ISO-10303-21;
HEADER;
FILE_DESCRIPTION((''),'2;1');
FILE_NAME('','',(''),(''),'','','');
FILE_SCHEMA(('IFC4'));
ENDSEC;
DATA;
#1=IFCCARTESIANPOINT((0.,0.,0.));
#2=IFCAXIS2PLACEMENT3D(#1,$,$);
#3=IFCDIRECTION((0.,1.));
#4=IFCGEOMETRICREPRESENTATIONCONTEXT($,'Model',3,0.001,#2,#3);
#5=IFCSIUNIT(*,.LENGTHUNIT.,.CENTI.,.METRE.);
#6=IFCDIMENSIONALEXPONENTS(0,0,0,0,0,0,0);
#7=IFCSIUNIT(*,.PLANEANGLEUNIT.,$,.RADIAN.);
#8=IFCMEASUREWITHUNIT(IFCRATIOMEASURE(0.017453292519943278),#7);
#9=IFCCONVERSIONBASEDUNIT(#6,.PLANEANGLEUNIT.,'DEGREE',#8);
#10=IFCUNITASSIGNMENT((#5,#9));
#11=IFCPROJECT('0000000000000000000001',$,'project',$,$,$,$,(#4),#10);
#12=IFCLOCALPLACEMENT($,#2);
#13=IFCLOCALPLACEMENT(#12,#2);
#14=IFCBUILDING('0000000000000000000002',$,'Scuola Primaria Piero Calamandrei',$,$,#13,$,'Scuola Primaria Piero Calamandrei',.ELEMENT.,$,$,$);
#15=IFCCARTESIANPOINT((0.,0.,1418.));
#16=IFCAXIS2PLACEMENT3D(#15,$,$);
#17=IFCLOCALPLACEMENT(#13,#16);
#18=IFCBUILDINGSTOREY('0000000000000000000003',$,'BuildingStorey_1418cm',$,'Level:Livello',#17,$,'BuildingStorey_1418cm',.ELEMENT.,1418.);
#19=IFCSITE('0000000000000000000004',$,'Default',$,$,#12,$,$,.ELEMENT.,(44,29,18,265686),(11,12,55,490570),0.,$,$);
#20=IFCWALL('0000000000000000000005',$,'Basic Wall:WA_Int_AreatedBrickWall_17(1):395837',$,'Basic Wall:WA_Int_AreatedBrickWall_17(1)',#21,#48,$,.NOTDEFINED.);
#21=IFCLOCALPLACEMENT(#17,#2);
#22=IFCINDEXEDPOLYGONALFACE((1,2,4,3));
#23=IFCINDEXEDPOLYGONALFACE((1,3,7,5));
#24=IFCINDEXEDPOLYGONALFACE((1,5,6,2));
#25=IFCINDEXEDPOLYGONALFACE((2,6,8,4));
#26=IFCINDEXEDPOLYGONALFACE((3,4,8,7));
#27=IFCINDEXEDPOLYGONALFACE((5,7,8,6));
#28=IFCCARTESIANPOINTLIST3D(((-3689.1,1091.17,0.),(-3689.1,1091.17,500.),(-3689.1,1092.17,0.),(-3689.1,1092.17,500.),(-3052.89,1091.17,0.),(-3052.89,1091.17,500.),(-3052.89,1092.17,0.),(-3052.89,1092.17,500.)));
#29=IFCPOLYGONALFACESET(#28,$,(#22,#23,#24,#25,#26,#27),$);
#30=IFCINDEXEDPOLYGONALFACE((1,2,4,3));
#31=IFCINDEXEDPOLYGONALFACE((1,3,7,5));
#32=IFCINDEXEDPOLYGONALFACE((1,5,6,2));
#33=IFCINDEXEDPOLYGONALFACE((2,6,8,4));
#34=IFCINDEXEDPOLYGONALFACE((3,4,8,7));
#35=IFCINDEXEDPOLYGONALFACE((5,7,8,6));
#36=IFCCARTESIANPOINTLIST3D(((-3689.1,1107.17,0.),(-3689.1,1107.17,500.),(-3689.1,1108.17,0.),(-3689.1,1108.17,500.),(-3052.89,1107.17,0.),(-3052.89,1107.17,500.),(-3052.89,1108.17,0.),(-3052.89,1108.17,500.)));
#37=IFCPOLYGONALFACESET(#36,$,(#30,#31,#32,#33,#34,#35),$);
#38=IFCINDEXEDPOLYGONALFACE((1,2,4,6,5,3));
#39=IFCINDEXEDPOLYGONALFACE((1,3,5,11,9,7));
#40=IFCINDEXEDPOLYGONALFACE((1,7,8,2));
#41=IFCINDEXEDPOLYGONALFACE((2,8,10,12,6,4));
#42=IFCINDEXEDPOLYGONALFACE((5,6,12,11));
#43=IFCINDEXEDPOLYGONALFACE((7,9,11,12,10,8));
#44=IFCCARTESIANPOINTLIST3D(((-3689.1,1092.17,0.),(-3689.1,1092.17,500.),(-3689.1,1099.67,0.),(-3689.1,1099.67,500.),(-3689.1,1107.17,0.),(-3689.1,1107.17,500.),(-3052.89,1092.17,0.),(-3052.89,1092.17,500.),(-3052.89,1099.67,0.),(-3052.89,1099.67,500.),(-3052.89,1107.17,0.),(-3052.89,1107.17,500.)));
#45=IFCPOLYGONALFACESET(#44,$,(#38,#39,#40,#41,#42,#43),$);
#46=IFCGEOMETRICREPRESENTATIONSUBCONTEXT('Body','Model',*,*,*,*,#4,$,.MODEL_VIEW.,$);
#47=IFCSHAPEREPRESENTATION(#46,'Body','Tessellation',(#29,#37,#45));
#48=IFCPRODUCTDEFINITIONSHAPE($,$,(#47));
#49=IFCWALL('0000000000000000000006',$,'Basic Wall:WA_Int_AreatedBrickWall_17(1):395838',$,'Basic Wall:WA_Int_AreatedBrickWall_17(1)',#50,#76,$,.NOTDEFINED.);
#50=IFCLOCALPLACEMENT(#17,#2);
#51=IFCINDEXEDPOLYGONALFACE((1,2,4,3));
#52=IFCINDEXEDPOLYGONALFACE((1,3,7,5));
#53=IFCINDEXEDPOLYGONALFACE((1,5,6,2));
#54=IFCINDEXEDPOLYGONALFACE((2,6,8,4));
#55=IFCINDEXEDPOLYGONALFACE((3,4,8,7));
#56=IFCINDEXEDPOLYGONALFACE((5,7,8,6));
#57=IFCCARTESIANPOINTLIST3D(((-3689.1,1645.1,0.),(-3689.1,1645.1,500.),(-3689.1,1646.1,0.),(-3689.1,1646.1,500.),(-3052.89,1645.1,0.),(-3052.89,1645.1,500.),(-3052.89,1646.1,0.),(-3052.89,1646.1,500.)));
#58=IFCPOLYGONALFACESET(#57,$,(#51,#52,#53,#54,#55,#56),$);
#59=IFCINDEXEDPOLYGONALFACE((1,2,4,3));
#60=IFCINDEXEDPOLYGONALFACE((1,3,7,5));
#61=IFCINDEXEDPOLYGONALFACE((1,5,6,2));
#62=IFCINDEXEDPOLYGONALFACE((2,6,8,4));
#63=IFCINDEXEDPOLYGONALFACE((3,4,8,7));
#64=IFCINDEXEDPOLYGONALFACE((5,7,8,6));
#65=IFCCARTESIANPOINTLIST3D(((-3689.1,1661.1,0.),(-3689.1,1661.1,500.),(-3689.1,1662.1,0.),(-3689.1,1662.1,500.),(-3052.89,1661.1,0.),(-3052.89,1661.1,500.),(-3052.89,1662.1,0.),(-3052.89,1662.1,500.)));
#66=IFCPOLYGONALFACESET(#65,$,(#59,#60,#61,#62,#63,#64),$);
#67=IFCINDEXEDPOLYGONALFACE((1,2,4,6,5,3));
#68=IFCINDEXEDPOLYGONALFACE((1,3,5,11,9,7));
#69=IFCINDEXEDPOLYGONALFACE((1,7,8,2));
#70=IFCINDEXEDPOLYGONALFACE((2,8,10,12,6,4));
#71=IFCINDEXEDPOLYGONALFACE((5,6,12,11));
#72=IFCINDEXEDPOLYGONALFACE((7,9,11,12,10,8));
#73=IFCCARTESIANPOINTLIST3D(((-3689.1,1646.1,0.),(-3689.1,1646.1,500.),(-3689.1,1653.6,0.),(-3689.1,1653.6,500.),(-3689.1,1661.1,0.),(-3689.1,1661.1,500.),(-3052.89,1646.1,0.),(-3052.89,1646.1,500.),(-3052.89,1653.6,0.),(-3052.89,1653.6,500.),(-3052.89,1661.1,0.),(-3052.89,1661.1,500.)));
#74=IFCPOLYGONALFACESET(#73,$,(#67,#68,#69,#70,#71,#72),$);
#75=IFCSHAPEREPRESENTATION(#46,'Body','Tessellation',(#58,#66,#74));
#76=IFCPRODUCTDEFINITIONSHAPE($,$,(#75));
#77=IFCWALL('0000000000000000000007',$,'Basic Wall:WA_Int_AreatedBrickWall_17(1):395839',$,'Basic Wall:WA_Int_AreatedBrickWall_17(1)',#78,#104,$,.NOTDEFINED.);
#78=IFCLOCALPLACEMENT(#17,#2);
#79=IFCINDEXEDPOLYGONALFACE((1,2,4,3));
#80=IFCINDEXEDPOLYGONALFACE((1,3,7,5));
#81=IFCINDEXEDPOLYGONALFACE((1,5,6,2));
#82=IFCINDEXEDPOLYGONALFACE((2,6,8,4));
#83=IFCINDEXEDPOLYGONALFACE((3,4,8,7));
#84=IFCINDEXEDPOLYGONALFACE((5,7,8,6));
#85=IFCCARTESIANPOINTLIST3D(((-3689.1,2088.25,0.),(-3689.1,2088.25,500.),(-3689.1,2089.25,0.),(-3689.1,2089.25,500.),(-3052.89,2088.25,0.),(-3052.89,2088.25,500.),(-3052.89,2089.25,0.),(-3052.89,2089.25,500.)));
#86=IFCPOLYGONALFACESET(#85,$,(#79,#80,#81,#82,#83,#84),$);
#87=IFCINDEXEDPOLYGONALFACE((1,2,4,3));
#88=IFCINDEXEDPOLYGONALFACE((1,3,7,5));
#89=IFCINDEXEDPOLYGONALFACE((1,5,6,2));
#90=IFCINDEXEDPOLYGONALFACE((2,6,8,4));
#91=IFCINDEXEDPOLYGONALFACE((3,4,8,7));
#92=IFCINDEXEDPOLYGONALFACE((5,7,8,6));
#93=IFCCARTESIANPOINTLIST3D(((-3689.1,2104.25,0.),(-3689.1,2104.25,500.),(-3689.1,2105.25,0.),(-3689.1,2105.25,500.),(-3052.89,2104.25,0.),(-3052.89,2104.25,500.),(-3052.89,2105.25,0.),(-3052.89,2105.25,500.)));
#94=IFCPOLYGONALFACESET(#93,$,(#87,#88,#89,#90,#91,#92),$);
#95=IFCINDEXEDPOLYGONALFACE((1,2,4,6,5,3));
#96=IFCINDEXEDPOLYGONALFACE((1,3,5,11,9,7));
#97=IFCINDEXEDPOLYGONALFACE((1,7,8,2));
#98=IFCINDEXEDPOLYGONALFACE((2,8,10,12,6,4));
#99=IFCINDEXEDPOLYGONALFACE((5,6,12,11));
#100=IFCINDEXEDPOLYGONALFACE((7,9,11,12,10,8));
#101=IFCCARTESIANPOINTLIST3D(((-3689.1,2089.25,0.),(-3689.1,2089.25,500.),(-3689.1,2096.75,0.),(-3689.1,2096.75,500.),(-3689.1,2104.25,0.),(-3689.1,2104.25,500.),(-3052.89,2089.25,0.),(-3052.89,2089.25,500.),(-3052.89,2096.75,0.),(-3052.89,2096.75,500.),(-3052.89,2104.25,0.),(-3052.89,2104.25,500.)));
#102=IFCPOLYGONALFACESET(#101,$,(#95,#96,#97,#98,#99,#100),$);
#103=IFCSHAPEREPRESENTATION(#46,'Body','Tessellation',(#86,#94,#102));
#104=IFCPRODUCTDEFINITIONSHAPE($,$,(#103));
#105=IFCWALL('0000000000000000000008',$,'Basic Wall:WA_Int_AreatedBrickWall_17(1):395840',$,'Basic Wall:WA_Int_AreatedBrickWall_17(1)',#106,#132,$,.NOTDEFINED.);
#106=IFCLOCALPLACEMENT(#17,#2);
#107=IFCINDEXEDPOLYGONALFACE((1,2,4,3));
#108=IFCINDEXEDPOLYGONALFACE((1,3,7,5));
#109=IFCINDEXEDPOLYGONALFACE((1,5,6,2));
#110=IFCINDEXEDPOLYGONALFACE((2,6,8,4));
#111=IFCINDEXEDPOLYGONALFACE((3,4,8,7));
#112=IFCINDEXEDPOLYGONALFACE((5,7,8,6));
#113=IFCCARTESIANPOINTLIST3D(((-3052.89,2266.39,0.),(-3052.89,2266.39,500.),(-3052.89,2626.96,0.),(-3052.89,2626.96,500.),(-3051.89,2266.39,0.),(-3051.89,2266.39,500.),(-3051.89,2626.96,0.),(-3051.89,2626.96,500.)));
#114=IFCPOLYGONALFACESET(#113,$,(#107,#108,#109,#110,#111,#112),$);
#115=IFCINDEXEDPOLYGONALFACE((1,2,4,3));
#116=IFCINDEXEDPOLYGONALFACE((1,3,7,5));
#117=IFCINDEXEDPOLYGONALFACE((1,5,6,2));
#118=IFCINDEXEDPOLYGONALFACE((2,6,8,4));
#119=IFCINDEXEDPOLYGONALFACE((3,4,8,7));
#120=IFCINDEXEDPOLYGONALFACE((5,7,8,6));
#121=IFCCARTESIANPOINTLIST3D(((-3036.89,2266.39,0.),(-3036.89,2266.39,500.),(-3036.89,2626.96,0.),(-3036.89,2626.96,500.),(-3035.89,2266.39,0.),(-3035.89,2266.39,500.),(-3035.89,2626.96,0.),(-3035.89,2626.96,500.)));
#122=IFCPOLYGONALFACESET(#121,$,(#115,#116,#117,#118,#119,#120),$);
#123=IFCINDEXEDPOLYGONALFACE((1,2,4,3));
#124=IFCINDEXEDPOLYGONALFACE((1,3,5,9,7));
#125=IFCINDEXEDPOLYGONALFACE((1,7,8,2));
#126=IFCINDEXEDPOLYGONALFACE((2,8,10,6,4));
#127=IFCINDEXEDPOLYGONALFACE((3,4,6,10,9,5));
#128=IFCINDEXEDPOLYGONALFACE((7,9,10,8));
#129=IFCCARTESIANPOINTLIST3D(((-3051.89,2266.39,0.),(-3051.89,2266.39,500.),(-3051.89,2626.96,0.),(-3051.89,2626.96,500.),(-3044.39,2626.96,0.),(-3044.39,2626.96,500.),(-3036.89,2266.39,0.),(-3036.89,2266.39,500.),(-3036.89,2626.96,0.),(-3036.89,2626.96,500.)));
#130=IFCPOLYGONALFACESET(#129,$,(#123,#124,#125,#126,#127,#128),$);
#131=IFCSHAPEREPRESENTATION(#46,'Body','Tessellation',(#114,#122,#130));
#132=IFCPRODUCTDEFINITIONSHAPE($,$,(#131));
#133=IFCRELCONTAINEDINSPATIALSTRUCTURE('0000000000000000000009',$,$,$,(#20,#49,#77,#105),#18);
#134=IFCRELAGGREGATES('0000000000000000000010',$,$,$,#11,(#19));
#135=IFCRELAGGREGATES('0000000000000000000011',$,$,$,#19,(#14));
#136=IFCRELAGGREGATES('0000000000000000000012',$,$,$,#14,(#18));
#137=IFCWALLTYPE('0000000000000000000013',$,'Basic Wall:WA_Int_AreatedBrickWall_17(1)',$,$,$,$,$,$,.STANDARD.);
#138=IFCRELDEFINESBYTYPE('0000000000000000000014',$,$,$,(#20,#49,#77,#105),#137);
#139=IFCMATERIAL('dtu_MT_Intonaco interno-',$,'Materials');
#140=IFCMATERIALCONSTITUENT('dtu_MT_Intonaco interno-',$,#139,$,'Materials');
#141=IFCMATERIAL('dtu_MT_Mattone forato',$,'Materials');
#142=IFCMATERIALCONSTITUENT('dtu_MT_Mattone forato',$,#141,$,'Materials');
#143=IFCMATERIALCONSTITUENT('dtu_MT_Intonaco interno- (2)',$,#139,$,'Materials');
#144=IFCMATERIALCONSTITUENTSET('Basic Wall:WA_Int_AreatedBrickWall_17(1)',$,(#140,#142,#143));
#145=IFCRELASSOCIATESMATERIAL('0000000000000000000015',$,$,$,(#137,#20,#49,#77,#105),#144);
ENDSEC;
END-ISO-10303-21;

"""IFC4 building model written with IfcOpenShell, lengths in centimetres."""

from ifc_helpers import new_model, entity, si_unit, converted_unit, direction, frame, origin, place, context, subcontext, project, spatial, indexed_curve, outline, extrude, material, constituent, constituent_set, type_object, element, save


model = new_model("IFC4")

# Units and contexts
model_context = context("Model", 3, precision=0.001, world=origin(), true_north=direction((0.0, 1.0)))
body_context = subcontext(model_context, "Body", "Model", "MODEL_VIEW")
ifc_project = project(units=[si_unit("LENGTHUNIT", "METRE", prefix="CENTI"), converted_unit("PLANEANGLEUNIT", "DEGREE", entity("IfcRatioMeasure", 0.017453292519943278), si_unit("PLANEANGLEUNIT", "RADIAN"), dimensions=[0, 0, 0, 0, 0, 0, 0])], contexts=[model_context])

# Site, building, storey
site_placement = place(None, origin())
site = spatial("IfcSite", under=ifc_project, at=site_placement, Name="Default", CompositionType="ELEMENT", RefLatitude=(44, 29, 18, 265686), RefLongitude=(11, 12, 55, 490570), RefElevation=0.0)
building_placement = place(site_placement, origin())
building = spatial("IfcBuilding", under=site, at=building_placement, Name="Scuola Primaria Piero Calamandrei", LongName="Scuola Primaria Piero Calamandrei", CompositionType="ELEMENT")
storey_placement = place(building_placement, frame((0.0, 0.0, 1418.0)))
storey = spatial("IfcBuildingStorey", under=building, at=storey_placement, Name="BuildingStorey_1418cm", ObjectType="Level:Livello", LongName="BuildingStorey_1418cm", CompositionType="ELEMENT", Elevation=1418.0)

# Shared definitions
ifc_material_1 = material(Name="dtu_MT_Intonaco interno-", Category="Materials")
ifc_constituent_1 = constituent(ifc_material_1, Name="dtu_MT_Intonaco interno-", Category="Materials")
ifc_material_2 = material(Name="dtu_MT_Mattone forato", Category="Materials")
ifc_constituent_2 = constituent(ifc_material_2, Name="dtu_MT_Mattone forato", Category="Materials")
ifc_constituent_3 = constituent(ifc_material_1, Name="dtu_MT_Intonaco interno- (2)", Category="Materials")
ifc_constituent_set_1 = constituent_set(constituents=[ifc_constituent_1, ifc_constituent_2, ifc_constituent_3], Name="Basic Wall:WA_Int_AreatedBrickWall_17(1)")
wall_type_1 = type_object("IfcWallType", Name="Basic Wall:WA_Int_AreatedBrickWall_17(1)", PredefinedType="STANDARD", material=ifc_constituent_set_1)

# Walls
wall_1_placement = place(storey_placement, frame((-3689.1, 1099.67, 0.0)))
element("IfcWall", 1, at=wall_1_placement, inside=storey, type_object=wall_type_1, material=ifc_constituent_set_1, Name="Basic Wall:WA_Int_AreatedBrickWall_17(1):395837", ObjectType="Basic Wall:WA_Int_AreatedBrickWall_17(1)", PredefinedType="NOTDEFINED", context=body_context, shape_type="SweptSolid", body=[
    extrude(outline(indexed_curve([(-0.5, -318.1), (0.5, -318.1), (0.5, 318.1), (-0.5, 318.1), (-0.5, -318.1)], self_intersect=False)), frame((318.1, -8.0, 0.0), z_axis=(0.0, 0.0, 1.0), x_axis=(0.0, 1.0, 0.0)), (0.0, 0.0, 1.0), 500.0),
    extrude(outline(indexed_curve([(-0.5, -318.1), (0.5, -318.1), (0.5, 318.1), (-0.5, 318.1), (-0.5, -318.1)], self_intersect=False)), frame((318.1, 8.0, 0.0), z_axis=(0.0, 0.0, 1.0), x_axis=(0.0, -1.0, 0.0)), (0.0, 0.0, 1.0), 500.0),
    extrude(outline(indexed_curve([(-318.1, -7.5), (318.1, -7.5), (318.1, 0.0), (318.1, 7.5), (-318.1, 7.5), (-318.1, 0.0), (-318.1, -7.5)], self_intersect=False)), frame((318.1, 0.0, 0.0)), (0.0, 0.0, 1.0), 500.0),
])
wall_2_placement = place(storey_placement, frame((-3689.1, 1653.6, 0.0)))
element("IfcWall", 2, at=wall_2_placement, inside=storey, type_object=wall_type_1, material=ifc_constituent_set_1, Name="Basic Wall:WA_Int_AreatedBrickWall_17(1):395838", ObjectType="Basic Wall:WA_Int_AreatedBrickWall_17(1)", PredefinedType="NOTDEFINED", context=body_context, shape_type="SweptSolid", body=[
    extrude(outline(indexed_curve([(-0.5, -318.1), (0.5, -318.1), (0.5, 318.1), (-0.5, 318.1), (-0.5, -318.1)], self_intersect=False)), frame((318.1, -8.0, 0.0), z_axis=(0.0, 0.0, 1.0), x_axis=(0.0, 1.0, 0.0)), (0.0, 0.0, 1.0), 500.0),
    extrude(outline(indexed_curve([(-0.5, -318.1), (0.5, -318.1), (0.5, 318.1), (-0.5, 318.1), (-0.5, -318.1)], self_intersect=False)), frame((318.1, 8.0, 0.0), z_axis=(0.0, 0.0, 1.0), x_axis=(0.0, -1.0, 0.0)), (0.0, 0.0, 1.0), 500.0),
    extrude(outline(indexed_curve([(-318.1, -7.5), (318.1, -7.5), (318.1, 0.0), (318.1, 7.5), (-318.1, 7.5), (-318.1, 0.0), (-318.1, -7.5)], self_intersect=False)), frame((318.1, 0.0, 0.0)), (0.0, 0.0, 1.0), 500.0),
])
wall_3_placement = place(storey_placement, frame((-3689.1, 2096.75, 0.0)))
element("IfcWall", 3, at=wall_3_placement, inside=storey, type_object=wall_type_1, material=ifc_constituent_set_1, Name="Basic Wall:WA_Int_AreatedBrickWall_17(1):395839", ObjectType="Basic Wall:WA_Int_AreatedBrickWall_17(1)", PredefinedType="NOTDEFINED", context=body_context, shape_type="SweptSolid", body=[
    extrude(outline(indexed_curve([(-0.5, -318.1), (0.5, -318.1), (0.5, 318.1), (-0.5, 318.1), (-0.5, -318.1)], self_intersect=False)), frame((318.1, -8.0, 0.0), z_axis=(0.0, 0.0, 1.0), x_axis=(0.0, 1.0, 0.0)), (0.0, 0.0, 1.0), 500.0),
    extrude(outline(indexed_curve([(-0.5, -318.1), (0.5, -318.1), (0.5, 318.1), (-0.5, 318.1), (-0.5, -318.1)], self_intersect=False)), frame((318.1, 8.0, 0.0), z_axis=(0.0, 0.0, 1.0), x_axis=(0.0, -1.0, 0.0)), (0.0, 0.0, 1.0), 500.0),
    extrude(outline(indexed_curve([(-318.1, -7.5), (318.1, -7.5), (318.1, 0.0), (318.1, 7.5), (-318.1, 7.5), (-318.1, 0.0), (-318.1, -7.5)], self_intersect=False)), frame((318.1, 0.0, 0.0)), (0.0, 0.0, 1.0), 500.0),
])
wall_4_placement = place(storey_placement, frame((-3044.39, 2626.96, 0.0), z_axis=(0.0, 0.0, 1.0), x_axis=(0.0, -1.0, 0.0)))
element("IfcWall", 4, at=wall_4_placement, inside=storey, type_object=wall_type_1, material=ifc_constituent_set_1, Name="Basic Wall:WA_Int_AreatedBrickWall_17(1):395840", ObjectType="Basic Wall:WA_Int_AreatedBrickWall_17(1)", PredefinedType="NOTDEFINED", context=body_context, shape_type="SweptSolid", body=[
    extrude(outline(indexed_curve([(-0.5, -180.29), (0.5, -180.29), (0.5, 180.29), (-0.5, 180.29), (-0.5, -180.29)], self_intersect=False)), frame((180.29, -8.0, 0.0), z_axis=(0.0, 0.0, 1.0), x_axis=(0.0, 1.0, 0.0)), (0.0, 0.0, 1.0), 500.0),
    extrude(outline(indexed_curve([(-0.5, -180.29), (0.5, -180.29), (0.5, 180.29), (-0.5, 180.29), (-0.5, -180.29)], self_intersect=False)), frame((180.29, 8.0, 0.0), z_axis=(0.0, 0.0, 1.0), x_axis=(0.0, -1.0, 0.0)), (0.0, 0.0, 1.0), 500.0),
    extrude(outline(indexed_curve([(-144.23, -7.5), (216.34, -7.5), (216.34, 7.5), (-144.23, 7.5), (-144.23, 0.0), (-144.23, -7.5)], self_intersect=False)), frame((144.23, 0.0, 0.0)), (0.0, 0.0, 1.0), 500.0),
])

save(model, "model.ifc")
